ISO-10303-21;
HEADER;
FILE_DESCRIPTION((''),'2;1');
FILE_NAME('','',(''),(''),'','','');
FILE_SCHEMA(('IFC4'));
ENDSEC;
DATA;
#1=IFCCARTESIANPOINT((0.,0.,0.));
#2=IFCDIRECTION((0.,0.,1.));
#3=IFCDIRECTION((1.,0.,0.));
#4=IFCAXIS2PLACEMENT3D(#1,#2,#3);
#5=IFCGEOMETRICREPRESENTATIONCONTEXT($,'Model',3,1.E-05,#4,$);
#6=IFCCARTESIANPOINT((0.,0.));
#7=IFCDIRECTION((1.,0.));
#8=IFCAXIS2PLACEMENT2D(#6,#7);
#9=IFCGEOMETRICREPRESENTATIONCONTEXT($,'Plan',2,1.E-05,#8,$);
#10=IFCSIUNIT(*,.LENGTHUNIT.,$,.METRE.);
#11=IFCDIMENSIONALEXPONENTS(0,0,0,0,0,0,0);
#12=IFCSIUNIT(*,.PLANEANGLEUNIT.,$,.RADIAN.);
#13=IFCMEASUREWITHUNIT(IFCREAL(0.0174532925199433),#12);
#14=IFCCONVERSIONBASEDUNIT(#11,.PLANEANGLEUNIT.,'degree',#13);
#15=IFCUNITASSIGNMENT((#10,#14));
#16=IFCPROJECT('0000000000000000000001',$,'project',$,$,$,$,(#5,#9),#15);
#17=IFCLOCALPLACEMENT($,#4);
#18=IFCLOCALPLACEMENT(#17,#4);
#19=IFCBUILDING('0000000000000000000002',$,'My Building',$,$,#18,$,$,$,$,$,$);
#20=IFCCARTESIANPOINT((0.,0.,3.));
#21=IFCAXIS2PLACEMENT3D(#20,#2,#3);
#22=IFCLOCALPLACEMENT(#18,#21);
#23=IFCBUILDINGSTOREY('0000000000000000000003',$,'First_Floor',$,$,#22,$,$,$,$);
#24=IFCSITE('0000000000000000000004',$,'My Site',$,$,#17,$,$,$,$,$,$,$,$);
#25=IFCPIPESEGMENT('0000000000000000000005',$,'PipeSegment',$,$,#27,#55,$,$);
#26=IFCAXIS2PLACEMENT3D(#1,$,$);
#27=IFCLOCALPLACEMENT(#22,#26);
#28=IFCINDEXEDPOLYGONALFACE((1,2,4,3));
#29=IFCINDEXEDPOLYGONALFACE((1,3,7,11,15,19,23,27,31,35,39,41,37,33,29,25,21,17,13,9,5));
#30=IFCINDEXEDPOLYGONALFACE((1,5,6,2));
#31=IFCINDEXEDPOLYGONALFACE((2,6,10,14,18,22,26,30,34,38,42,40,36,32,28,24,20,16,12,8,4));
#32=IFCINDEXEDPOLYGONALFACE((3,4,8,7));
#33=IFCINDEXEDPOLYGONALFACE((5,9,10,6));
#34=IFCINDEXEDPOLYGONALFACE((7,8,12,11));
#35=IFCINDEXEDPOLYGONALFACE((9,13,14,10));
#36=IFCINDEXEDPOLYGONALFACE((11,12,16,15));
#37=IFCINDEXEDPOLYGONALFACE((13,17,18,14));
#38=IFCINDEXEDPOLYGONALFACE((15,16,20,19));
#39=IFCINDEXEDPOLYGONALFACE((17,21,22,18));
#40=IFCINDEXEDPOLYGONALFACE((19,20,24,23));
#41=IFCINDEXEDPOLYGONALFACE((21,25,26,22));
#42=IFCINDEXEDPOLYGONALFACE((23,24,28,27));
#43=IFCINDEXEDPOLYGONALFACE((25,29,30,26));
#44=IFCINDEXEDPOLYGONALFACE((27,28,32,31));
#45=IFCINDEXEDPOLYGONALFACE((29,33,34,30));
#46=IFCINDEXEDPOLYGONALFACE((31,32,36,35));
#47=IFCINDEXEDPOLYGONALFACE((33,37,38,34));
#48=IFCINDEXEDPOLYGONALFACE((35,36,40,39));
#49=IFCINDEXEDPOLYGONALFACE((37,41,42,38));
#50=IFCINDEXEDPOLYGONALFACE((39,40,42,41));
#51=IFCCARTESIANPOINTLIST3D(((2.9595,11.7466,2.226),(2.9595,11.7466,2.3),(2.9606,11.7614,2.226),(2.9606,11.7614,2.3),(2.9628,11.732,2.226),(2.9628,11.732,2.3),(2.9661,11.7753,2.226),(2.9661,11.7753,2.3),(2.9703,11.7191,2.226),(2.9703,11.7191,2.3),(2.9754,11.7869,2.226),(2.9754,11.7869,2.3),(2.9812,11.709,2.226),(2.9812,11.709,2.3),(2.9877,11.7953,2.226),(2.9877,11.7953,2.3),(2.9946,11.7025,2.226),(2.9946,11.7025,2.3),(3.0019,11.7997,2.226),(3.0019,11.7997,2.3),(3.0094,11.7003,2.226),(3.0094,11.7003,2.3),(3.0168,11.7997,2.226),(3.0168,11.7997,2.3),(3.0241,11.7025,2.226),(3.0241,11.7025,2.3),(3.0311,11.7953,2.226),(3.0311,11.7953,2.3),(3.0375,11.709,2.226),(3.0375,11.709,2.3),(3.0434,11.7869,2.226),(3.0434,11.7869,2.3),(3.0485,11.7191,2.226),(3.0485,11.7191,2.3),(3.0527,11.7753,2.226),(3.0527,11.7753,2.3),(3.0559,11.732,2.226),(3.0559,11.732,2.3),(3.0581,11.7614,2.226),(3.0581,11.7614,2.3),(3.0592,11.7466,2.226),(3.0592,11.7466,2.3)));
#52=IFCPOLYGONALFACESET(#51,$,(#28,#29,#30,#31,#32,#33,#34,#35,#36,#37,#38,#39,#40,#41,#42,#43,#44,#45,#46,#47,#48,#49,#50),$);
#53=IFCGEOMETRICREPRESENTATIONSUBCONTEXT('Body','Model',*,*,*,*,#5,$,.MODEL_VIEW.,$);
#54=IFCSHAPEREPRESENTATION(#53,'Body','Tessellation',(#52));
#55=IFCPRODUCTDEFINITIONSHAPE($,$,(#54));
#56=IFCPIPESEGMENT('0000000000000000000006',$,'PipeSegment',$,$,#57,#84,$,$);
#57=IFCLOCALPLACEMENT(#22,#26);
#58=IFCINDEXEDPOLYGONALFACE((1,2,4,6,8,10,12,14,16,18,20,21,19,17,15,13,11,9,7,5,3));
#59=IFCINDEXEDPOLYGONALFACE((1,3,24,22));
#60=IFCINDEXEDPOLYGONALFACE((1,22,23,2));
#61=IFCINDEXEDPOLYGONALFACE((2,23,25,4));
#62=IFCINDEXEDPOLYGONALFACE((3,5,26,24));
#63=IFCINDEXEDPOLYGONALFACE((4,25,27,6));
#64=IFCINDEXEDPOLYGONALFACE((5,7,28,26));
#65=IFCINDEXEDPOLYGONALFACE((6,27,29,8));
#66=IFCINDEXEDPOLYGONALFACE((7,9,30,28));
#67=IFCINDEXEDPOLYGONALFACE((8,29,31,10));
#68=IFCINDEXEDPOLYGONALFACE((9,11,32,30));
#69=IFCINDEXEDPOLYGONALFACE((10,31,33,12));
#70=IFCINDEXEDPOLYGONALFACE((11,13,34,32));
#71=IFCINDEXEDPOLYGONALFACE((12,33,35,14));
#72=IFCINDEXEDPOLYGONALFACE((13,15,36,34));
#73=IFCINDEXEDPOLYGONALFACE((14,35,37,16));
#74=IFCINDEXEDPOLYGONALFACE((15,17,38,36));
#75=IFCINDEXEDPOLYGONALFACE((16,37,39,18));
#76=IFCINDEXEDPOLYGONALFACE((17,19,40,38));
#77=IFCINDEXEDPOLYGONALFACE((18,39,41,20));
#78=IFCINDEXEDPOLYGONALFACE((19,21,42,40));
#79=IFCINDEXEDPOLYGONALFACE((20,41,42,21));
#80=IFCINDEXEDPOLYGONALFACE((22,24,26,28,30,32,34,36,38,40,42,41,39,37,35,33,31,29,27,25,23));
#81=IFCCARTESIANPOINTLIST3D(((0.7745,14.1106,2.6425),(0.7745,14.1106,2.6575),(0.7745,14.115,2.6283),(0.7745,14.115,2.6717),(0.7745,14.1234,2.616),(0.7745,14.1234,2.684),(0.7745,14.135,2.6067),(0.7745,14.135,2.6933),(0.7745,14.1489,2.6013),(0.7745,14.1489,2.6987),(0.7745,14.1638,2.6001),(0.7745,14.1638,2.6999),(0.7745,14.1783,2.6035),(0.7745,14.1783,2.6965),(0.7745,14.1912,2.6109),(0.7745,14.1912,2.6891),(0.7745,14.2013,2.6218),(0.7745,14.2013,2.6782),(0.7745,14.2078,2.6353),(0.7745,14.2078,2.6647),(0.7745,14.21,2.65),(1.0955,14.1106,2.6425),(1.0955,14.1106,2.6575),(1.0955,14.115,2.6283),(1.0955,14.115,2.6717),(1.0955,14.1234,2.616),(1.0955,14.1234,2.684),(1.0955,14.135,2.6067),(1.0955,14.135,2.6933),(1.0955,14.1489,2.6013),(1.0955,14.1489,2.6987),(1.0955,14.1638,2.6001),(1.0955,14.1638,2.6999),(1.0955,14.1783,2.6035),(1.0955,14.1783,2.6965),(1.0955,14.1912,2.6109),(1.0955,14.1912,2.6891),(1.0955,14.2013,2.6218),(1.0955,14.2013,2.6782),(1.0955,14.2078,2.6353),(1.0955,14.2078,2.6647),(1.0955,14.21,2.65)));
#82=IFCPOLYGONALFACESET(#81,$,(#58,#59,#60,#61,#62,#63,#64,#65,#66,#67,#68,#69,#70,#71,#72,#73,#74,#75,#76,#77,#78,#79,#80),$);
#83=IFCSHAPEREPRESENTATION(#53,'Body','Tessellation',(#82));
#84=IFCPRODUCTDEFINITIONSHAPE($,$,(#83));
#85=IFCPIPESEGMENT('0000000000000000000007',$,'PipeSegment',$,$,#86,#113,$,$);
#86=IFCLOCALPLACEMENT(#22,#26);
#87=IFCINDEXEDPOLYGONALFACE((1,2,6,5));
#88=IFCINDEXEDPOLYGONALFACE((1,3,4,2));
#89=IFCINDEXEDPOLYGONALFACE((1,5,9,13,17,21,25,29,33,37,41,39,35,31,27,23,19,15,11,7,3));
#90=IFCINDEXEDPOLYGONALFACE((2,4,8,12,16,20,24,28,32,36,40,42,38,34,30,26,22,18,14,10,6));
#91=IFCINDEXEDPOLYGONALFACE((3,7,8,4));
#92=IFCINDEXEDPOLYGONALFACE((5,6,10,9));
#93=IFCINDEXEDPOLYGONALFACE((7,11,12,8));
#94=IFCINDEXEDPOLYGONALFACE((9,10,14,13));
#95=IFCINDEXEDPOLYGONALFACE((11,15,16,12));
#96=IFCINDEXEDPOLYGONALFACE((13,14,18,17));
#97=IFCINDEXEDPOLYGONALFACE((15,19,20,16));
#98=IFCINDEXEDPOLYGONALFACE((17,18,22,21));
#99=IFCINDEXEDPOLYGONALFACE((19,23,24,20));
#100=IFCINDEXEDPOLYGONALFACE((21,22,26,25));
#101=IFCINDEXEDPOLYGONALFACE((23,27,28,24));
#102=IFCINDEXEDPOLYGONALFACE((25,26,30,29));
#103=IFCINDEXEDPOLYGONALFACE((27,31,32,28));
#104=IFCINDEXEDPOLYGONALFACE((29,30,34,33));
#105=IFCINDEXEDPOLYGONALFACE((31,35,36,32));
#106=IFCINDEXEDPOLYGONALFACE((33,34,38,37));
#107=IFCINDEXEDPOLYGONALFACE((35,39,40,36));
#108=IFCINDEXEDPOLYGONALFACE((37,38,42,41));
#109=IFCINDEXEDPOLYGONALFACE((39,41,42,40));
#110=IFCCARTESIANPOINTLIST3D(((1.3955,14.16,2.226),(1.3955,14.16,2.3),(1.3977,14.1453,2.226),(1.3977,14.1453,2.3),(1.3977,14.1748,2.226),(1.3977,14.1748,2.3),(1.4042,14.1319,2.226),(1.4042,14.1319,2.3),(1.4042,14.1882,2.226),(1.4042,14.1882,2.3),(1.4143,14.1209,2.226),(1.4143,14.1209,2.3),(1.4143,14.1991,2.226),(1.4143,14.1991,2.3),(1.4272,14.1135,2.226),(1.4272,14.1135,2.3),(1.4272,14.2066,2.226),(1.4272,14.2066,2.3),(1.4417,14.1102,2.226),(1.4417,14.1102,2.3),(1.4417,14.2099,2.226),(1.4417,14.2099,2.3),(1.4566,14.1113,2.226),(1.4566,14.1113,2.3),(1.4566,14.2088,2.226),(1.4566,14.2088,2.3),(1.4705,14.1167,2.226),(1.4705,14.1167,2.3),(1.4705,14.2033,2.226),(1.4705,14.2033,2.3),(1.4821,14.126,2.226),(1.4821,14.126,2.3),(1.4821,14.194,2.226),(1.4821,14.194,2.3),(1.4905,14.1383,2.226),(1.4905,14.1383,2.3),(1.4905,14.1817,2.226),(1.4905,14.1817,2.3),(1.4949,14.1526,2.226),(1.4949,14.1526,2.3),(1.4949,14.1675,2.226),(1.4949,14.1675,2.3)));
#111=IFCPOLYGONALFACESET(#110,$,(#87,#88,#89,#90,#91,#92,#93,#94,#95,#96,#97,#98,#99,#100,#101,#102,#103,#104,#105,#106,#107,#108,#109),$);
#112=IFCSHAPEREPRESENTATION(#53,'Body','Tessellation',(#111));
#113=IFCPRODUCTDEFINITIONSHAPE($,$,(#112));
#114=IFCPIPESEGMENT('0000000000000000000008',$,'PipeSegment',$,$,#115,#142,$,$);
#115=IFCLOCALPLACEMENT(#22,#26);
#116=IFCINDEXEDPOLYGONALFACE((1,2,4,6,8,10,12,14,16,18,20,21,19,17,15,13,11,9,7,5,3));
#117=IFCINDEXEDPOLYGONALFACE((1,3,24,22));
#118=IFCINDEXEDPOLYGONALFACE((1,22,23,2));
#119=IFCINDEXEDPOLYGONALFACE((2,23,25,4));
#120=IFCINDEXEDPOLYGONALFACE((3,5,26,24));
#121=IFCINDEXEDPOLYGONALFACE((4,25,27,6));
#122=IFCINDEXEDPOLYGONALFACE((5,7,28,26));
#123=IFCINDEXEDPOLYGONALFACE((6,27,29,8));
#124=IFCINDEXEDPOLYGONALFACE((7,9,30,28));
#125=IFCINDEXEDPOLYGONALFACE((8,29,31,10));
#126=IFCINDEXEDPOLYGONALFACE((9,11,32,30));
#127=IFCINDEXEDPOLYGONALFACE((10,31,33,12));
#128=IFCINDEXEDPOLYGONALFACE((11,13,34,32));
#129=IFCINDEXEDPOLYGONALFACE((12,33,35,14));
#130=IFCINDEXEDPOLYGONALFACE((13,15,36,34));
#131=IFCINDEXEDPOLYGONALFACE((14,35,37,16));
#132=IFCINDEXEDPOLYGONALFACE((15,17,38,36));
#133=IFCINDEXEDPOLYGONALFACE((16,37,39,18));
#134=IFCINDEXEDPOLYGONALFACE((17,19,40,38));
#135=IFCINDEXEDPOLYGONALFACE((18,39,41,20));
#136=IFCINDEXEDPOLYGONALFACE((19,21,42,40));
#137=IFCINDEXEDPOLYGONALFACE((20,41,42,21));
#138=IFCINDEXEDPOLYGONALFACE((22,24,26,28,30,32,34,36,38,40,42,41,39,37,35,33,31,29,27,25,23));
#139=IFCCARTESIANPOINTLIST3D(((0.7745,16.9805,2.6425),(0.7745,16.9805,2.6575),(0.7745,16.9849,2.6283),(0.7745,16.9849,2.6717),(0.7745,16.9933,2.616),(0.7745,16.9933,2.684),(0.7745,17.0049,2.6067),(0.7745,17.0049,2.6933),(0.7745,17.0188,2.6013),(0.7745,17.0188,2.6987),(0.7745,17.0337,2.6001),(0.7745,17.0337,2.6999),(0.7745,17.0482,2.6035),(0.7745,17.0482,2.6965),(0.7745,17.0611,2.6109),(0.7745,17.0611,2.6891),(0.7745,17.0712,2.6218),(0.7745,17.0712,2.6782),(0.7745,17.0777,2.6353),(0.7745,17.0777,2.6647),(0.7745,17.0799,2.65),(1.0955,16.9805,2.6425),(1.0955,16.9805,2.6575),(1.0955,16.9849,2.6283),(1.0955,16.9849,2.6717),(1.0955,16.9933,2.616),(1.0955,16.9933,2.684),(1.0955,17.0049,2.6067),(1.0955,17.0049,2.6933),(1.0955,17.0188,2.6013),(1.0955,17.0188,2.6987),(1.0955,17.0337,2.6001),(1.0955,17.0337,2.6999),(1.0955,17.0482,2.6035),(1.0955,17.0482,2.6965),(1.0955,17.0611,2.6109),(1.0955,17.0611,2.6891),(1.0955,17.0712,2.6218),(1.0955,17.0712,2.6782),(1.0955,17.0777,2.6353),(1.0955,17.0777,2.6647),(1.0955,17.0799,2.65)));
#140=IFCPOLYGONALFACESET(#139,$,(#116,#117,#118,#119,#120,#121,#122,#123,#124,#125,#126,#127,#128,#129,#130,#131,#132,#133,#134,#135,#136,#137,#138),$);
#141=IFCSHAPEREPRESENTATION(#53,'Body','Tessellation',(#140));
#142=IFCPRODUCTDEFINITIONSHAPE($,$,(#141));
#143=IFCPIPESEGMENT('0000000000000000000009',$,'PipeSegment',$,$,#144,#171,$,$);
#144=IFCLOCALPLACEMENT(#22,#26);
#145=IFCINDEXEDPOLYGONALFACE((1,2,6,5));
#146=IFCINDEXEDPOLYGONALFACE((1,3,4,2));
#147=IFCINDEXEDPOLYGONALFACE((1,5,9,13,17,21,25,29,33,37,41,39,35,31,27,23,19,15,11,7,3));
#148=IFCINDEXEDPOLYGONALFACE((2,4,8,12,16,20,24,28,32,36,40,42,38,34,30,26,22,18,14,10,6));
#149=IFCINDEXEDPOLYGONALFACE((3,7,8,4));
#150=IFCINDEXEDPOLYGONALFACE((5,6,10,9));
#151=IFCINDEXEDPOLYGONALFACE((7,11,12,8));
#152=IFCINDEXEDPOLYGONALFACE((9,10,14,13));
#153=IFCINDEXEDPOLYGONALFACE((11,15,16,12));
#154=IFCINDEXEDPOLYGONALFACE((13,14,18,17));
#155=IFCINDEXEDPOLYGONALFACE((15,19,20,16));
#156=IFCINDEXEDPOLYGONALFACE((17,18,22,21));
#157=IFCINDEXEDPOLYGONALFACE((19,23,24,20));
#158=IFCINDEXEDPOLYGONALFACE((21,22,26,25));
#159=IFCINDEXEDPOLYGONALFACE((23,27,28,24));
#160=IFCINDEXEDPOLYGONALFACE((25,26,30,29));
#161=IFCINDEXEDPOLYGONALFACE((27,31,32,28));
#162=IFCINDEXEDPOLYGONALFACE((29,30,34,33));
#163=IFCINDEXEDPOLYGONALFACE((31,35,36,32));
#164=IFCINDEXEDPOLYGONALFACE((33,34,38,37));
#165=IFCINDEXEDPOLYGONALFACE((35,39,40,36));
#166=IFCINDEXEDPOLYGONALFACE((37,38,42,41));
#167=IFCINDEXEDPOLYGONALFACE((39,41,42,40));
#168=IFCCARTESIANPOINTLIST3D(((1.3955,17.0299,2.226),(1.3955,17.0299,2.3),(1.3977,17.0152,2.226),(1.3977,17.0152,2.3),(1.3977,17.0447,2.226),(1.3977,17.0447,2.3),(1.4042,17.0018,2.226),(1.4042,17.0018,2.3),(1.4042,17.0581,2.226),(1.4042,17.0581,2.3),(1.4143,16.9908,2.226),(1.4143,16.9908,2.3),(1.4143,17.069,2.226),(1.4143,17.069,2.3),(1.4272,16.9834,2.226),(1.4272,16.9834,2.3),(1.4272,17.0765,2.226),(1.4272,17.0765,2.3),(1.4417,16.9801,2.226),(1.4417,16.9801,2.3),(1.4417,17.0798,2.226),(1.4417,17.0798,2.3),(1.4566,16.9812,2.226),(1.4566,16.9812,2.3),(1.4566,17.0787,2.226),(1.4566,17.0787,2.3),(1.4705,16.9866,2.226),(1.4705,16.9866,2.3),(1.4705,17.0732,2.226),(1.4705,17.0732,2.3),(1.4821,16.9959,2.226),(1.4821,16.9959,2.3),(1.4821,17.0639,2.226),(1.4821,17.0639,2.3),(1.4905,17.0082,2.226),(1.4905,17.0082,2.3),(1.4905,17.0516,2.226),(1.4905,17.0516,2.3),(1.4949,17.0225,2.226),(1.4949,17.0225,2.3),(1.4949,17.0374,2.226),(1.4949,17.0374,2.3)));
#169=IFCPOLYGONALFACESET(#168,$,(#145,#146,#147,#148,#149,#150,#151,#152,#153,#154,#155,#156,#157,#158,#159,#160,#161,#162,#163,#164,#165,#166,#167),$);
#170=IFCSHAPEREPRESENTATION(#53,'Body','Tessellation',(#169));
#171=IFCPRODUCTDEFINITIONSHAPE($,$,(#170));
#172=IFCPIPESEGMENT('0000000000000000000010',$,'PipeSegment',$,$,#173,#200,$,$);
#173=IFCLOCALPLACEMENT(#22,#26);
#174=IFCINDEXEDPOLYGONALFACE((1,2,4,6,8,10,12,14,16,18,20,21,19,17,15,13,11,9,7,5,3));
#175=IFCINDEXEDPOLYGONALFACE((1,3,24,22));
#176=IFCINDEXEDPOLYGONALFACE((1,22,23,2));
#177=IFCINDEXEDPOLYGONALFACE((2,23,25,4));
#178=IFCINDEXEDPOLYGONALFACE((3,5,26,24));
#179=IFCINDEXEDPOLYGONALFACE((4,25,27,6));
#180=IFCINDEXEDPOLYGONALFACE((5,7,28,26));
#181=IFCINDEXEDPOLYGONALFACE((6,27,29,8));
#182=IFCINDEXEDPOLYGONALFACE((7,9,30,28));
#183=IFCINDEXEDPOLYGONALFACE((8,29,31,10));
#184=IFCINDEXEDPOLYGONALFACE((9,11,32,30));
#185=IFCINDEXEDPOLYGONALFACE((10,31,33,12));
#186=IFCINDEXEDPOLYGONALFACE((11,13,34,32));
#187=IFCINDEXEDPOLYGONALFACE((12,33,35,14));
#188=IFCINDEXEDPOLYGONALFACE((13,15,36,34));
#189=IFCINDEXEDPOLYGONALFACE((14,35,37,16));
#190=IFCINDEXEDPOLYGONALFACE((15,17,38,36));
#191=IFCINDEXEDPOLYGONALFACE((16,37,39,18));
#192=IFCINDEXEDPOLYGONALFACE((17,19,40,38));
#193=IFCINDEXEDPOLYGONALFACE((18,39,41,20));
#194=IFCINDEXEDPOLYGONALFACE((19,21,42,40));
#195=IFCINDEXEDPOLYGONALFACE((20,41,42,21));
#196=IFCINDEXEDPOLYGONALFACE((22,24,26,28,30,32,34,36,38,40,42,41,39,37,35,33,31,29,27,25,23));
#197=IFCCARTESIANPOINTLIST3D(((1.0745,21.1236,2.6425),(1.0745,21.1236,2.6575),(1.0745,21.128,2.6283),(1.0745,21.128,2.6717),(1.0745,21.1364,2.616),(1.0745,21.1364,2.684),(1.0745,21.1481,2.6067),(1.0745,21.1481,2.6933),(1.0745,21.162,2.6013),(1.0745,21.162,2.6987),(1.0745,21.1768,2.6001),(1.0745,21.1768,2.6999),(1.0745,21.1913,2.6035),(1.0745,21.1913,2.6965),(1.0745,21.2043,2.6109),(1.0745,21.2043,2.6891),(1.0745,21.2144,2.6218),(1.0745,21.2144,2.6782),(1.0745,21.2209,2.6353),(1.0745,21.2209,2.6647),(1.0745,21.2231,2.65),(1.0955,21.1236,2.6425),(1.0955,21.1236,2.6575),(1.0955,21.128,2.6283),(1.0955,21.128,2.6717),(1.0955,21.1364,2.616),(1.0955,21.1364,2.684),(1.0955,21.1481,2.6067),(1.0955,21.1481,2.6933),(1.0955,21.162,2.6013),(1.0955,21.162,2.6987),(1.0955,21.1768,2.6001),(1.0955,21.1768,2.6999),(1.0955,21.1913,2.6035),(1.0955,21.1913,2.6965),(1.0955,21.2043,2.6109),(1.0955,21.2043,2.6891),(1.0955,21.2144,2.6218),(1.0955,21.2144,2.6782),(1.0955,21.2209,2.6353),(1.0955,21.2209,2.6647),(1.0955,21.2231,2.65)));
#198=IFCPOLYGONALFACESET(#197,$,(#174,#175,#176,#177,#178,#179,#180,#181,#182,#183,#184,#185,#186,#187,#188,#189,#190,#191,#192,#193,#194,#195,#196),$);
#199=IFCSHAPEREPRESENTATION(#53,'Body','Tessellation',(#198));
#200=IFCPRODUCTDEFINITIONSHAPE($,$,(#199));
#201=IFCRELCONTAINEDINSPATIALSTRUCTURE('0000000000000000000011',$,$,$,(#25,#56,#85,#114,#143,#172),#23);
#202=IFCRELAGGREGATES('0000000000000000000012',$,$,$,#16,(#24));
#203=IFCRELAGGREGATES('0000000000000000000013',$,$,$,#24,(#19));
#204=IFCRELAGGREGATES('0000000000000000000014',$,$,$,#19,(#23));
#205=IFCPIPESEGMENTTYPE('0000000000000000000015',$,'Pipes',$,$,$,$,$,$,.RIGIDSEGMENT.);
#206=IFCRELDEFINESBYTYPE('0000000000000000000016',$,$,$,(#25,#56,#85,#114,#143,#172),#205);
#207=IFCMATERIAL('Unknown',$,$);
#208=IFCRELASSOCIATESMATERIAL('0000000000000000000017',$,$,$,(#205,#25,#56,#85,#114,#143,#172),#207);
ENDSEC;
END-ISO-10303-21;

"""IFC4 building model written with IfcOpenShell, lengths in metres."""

from ifc_helpers import new_model, entity, si_unit, converted_unit, frame, origin_with_axes, origin_2d_with_axis, place, context, subcontext, project, spatial, circle, extrude, material, material_profile, profile_set, profile_usage, type_object, element, save


model = new_model("IFC4")

# Units and contexts
model_context = context("Model", 3, precision=1e-05, world=origin_with_axes())
plan_context = context("Plan", 2, precision=1e-05, world=origin_2d_with_axis())
body_context = subcontext(model_context, "Body", "Model", "MODEL_VIEW")
ifc_project = project(units=[si_unit("LENGTHUNIT", "METRE"), converted_unit("PLANEANGLEUNIT", "degree", entity("IfcReal", 0.0174532925199433), si_unit("PLANEANGLEUNIT", "RADIAN"), dimensions=[0, 0, 0, 0, 0, 0, 0])], contexts=[model_context, plan_context])

# Site, building, storey
site_placement = place(None, origin_with_axes())
site = spatial("IfcSite", under=ifc_project, at=site_placement, Name="My Site")
building_placement = place(site_placement, origin_with_axes())
building = spatial("IfcBuilding", under=site, at=building_placement, Name="My Building")
storey_placement = place(building_placement, frame((0.0, 0.0, 3.0), z_axis=(0.0, 0.0, 1.0), x_axis=(1.0, 0.0, 0.0)))
storey = spatial("IfcBuildingStorey", under=building, at=storey_placement, Name="First_Floor")

# Shared definitions
ifc_material = material(Name="Unknown")

# Pipe segments
ifc_material_profile_1 = material_profile(ifc_material, circle(Radius=0.05))
ifc_profile_set_1 = profile_set([ifc_material_profile_1])
ifc_profile_usage_1 = profile_usage(ifc_profile_set_1, cardinal=5)
pipe_segment_type = type_object("IfcPipeSegmentType", Name="Pipes", PredefinedType="RIGIDSEGMENT", material=ifc_profile_set_1)
pipe_segment_1_placement = place(storey_placement, frame((3.0094, 11.7503, 2.3), z_axis=(0.0, 0.0, -1.0), x_axis=(0.0, -1.0, 0.0)))
element("IfcPipeSegment", 1, at=pipe_segment_1_placement, inside=storey, type_object=pipe_segment_type, material=ifc_profile_usage_1, Name="PipeSegment", context=body_context, shape_type="SweptSolid", body=[
    extrude(circle(Radius=0.05), origin_with_axes(), (0.0, 0.0, 1.0), 0.074),
])
ifc_profile_usage_2 = profile_usage(ifc_profile_set_1, cardinal=5)
pipe_segment_2_placement = place(storey_placement, frame((0.7745, 14.16, 2.65), z_axis=(1.0, 0.0, 0.0), x_axis=(0.0, 1.0, 0.0)))
element("IfcPipeSegment", 2, at=pipe_segment_2_placement, inside=storey, type_object=pipe_segment_type, material=ifc_profile_usage_2, Name="PipeSegment", context=body_context, shape_type="SweptSolid", body=[
    extrude(circle(Radius=0.05), origin_with_axes(), (0.0, 0.0, 1.0), 0.321),
])
ifc_profile_usage_3 = profile_usage(ifc_profile_set_1, cardinal=5)
pipe_segment_3_placement = place(storey_placement, frame((1.4455, 14.16, 2.3), z_axis=(0.0, 0.0, -1.0), x_axis=(-1.0, 0.0, 0.0)))
element("IfcPipeSegment", 3, at=pipe_segment_3_placement, inside=storey, type_object=pipe_segment_type, material=ifc_profile_usage_3, Name="PipeSegment", context=body_context, shape_type="SweptSolid", body=[
    extrude(circle(Radius=0.05), origin_with_axes(), (0.0, 0.0, 1.0), 0.074),
])
ifc_profile_usage_4 = profile_usage(ifc_profile_set_1, cardinal=5)
pipe_segment_4_placement = place(storey_placement, frame((0.7745, 17.0299, 2.65), z_axis=(1.0, 0.0, 0.0), x_axis=(0.0, 1.0, 0.0)))
element("IfcPipeSegment", 4, at=pipe_segment_4_placement, inside=storey, type_object=pipe_segment_type, material=ifc_profile_usage_4, Name="PipeSegment", context=body_context, shape_type="SweptSolid", body=[
    extrude(circle(Radius=0.05), origin_with_axes(), (0.0, 0.0, 1.0), 0.321),
])
ifc_profile_usage_5 = profile_usage(ifc_profile_set_1, cardinal=5)
pipe_segment_5_placement = place(storey_placement, frame((1.4455, 17.0299, 2.3), z_axis=(0.0, 0.0, -1.0), x_axis=(-1.0, 0.0, 0.0)))
element("IfcPipeSegment", 5, at=pipe_segment_5_placement, inside=storey, type_object=pipe_segment_type, material=ifc_profile_usage_5, Name="PipeSegment", context=body_context, shape_type="SweptSolid", body=[
    extrude(circle(Radius=0.05), origin_with_axes(), (0.0, 0.0, 1.0), 0.074),
])
ifc_profile_usage_6 = profile_usage(ifc_profile_set_1, cardinal=5)
pipe_segment_6_placement = place(storey_placement, frame((1.0745, 21.1731, 2.65), z_axis=(1.0, 0.0, 0.0), x_axis=(0.0, 1.0, 0.0)))
element("IfcPipeSegment", 6, at=pipe_segment_6_placement, inside=storey, type_object=pipe_segment_type, material=ifc_profile_usage_6, Name="PipeSegment", context=body_context, shape_type="SweptSolid", body=[
    extrude(circle(Radius=0.05), origin_with_axes(), (0.0, 0.0, 1.0), 0.021),
])

save(model, "model.ifc")
